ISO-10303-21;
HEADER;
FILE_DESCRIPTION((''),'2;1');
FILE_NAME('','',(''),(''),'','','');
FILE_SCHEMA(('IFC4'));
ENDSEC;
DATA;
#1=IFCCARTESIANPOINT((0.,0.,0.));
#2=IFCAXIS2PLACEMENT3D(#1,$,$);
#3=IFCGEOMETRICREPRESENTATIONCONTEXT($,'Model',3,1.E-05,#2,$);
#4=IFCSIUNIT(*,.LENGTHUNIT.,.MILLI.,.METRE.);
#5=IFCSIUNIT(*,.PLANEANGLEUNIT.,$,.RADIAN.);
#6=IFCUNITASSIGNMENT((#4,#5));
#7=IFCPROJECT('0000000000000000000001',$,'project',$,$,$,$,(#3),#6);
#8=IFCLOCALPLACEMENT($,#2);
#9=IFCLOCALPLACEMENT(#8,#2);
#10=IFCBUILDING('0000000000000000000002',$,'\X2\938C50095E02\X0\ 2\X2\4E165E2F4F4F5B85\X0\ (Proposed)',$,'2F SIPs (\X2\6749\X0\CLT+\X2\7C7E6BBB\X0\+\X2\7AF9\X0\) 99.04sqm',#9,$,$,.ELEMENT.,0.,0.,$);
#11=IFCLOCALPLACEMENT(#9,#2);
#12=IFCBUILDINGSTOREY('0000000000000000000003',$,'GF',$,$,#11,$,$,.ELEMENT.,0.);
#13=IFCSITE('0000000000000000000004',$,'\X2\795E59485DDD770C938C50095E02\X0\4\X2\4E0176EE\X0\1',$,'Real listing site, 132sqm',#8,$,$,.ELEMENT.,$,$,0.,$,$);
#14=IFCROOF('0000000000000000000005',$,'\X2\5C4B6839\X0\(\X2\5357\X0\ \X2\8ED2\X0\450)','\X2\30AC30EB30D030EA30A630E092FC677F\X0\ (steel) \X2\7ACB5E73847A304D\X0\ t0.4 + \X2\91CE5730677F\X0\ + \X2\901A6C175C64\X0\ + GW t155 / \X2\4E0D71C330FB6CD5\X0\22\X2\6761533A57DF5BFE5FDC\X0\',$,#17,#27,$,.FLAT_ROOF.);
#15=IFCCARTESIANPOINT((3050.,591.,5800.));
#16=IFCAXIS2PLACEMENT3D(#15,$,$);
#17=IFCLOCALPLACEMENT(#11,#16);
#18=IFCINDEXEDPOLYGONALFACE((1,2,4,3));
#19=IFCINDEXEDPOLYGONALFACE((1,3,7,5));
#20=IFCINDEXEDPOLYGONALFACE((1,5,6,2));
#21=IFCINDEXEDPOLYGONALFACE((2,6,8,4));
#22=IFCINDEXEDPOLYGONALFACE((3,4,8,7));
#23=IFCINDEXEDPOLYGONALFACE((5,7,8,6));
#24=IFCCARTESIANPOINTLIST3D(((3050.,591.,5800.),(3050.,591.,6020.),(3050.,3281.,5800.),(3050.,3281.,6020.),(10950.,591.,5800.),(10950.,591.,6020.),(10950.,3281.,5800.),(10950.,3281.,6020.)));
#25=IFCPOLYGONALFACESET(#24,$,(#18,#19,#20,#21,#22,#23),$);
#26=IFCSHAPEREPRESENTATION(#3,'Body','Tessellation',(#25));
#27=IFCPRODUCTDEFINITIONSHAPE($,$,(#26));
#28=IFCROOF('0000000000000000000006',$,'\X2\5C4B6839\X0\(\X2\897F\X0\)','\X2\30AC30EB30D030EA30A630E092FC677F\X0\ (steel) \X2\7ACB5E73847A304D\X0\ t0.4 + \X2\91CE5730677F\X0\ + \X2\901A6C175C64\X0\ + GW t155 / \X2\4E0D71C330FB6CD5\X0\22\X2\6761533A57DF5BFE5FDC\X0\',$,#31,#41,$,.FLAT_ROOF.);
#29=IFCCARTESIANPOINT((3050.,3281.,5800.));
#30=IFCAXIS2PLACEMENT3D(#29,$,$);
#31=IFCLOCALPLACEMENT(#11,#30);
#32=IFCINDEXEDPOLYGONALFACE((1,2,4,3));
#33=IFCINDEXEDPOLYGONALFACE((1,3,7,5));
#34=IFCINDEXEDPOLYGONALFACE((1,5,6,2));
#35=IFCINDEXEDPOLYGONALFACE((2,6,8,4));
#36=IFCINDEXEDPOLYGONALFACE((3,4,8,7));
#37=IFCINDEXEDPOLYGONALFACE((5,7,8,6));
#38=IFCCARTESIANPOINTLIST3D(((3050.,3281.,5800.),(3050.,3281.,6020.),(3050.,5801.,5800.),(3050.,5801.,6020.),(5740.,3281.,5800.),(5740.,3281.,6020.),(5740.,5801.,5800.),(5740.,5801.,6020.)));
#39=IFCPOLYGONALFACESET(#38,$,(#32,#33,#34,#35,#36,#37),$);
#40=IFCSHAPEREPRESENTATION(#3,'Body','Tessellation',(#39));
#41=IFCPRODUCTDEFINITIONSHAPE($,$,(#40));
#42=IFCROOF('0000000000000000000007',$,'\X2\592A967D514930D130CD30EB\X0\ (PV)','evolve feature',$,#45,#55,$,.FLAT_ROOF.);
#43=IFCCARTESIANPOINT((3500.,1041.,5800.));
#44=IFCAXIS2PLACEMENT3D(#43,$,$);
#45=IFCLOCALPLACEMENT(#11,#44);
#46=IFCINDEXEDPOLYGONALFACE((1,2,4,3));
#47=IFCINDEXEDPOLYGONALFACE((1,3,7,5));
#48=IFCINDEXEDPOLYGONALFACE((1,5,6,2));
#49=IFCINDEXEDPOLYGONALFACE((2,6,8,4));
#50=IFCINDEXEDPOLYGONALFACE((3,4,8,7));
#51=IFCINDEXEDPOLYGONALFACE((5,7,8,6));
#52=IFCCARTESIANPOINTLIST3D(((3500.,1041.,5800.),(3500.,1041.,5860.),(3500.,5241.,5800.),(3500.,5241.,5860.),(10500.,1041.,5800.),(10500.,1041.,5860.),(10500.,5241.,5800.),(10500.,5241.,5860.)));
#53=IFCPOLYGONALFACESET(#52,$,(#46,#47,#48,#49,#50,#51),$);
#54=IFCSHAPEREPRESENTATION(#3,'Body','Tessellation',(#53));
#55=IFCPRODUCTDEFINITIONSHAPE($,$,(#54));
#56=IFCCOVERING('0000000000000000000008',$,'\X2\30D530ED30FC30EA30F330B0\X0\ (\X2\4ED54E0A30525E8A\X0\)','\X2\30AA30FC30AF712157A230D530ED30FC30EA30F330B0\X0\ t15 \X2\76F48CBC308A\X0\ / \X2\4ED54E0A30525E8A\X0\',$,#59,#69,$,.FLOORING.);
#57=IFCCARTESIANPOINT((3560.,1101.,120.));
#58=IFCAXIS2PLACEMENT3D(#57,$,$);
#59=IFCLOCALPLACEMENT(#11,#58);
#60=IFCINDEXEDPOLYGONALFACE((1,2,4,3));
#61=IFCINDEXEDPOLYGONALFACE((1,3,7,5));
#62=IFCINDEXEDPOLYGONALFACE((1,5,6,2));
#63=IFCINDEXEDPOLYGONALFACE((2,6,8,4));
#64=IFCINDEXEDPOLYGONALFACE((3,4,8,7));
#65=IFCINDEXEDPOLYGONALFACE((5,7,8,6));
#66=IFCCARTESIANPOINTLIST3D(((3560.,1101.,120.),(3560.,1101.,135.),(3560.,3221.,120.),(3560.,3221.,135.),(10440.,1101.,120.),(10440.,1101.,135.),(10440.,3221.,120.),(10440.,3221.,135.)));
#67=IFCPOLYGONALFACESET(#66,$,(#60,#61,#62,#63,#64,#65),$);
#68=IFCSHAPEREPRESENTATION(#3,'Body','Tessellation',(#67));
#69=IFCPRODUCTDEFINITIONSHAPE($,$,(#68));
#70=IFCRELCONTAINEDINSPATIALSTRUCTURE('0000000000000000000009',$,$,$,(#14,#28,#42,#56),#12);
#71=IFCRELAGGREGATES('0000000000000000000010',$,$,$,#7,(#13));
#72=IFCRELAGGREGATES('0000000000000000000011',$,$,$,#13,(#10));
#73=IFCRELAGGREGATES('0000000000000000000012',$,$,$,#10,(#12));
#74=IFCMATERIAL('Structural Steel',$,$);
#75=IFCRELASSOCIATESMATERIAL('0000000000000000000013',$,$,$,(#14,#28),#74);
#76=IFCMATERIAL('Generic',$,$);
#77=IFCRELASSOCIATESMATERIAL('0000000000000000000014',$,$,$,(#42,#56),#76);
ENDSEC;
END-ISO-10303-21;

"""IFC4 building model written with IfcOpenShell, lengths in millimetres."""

from ifc_helpers import new_model, si_unit, frame, frame_2d, origin, place, context, project, spatial, rectangle, extrude, material, element, save


model = new_model("IFC4")

# Units and contexts
model_context = context("Model", 3, precision=1e-05, world=origin())
ifc_project = project(units=[si_unit("LENGTHUNIT", "METRE", prefix="MILLI"), si_unit("PLANEANGLEUNIT", "RADIAN")], contexts=[model_context])

# Site, building, storey
site_placement = place(None, origin())
site = spatial("IfcSite", under=ifc_project, at=site_placement, Name="神奈川県鎌倉市4丁目1", ObjectType="Real listing site, 132sqm", CompositionType="ELEMENT", RefElevation=0.0)
building_placement = place(site_placement, origin())
building = spatial("IfcBuilding", under=site, at=building_placement, Name="鎌倉市 2世帯住宅 (Proposed)", ObjectType="2F SIPs (杉CLT+籾殻+竹) 99.04sqm", CompositionType="ELEMENT", ElevationOfRefHeight=0.0, ElevationOfTerrain=0.0)
storey_placement = place(building_placement, origin())
storey = spatial("IfcBuildingStorey", under=building, at=storey_placement, Name="GF", CompositionType="ELEMENT", Elevation=0.0)

# Shared definitions
ifc_material_1 = material(Name="Generic")

# Roofs
ifc_material_2 = material(Name="Structural Steel")
roof_1_placement = place(storey_placement, frame((3050.0, 591.0, 5800.0)))
element("IfcRoof", 1, at=roof_1_placement, inside=storey, material=ifc_material_2, Name="屋根(南 軒450)", Description="ガルバリウム鋼板 (steel) 立平葺き t0.4 + 野地板 + 通気層 + GW t155 / 不燃・法22条区域対応", PredefinedType="FLAT_ROOF", context=model_context, shape_type="SweptSolid", body=[
    extrude(rectangle(XDim=7900.0, YDim=2690.0, at=frame_2d((3950.0, 1345.0))), frame((3050.0, 591.0, 5800.0)), (0.0, 0.0, 1.0), 220.0),
])
roof_2_placement = place(storey_placement, frame((3050.0, 3281.0, 5800.0)))
element("IfcRoof", 2, at=roof_2_placement, inside=storey, material=ifc_material_2, Name="屋根(西)", Description="ガルバリウム鋼板 (steel) 立平葺き t0.4 + 野地板 + 通気層 + GW t155 / 不燃・法22条区域対応", PredefinedType="FLAT_ROOF", context=model_context, shape_type="SweptSolid", body=[
    extrude(rectangle(XDim=2690.0, YDim=2520.0, at=frame_2d((1345.0, 1260.0))), frame((3050.0, 3281.0, 5800.0)), (0.0, 0.0, 1.0), 220.0),
])
roof_3_placement = place(storey_placement, frame((3500.0, 1041.0, 5800.0)))
element("IfcRoof", 3, at=roof_3_placement, inside=storey, material=ifc_material_1, Name="太陽光パネル (PV)", Description="evolve feature", PredefinedType="FLAT_ROOF", context=model_context, shape_type="SweptSolid", body=[
    extrude(rectangle(XDim=7000.0, YDim=4200.0, at=frame_2d((3500.0, 2100.0))), frame((3500.0, 1041.0, 5800.0)), (0.0, 0.0, 1.0), 60.0),
])

# Covering
covering_placement = place(storey_placement, frame((3560.0, 1101.0, 120.0)))
element("IfcCovering", 4, at=covering_placement, inside=storey, material=ifc_material_1, Name="フローリング (仕上げ床)", Description="オーク無垢フローリング t15 直貼り / 仕上げ床", PredefinedType="FLOORING", context=model_context, shape_type="SweptSolid", body=[
    extrude(rectangle(XDim=6880.0, YDim=2120.0, at=frame_2d((3440.0, 1060.0))), frame((3560.0, 1101.0, 120.0)), (0.0, 0.0, 1.0), 15.0),
])

save(model, "model.ifc")
